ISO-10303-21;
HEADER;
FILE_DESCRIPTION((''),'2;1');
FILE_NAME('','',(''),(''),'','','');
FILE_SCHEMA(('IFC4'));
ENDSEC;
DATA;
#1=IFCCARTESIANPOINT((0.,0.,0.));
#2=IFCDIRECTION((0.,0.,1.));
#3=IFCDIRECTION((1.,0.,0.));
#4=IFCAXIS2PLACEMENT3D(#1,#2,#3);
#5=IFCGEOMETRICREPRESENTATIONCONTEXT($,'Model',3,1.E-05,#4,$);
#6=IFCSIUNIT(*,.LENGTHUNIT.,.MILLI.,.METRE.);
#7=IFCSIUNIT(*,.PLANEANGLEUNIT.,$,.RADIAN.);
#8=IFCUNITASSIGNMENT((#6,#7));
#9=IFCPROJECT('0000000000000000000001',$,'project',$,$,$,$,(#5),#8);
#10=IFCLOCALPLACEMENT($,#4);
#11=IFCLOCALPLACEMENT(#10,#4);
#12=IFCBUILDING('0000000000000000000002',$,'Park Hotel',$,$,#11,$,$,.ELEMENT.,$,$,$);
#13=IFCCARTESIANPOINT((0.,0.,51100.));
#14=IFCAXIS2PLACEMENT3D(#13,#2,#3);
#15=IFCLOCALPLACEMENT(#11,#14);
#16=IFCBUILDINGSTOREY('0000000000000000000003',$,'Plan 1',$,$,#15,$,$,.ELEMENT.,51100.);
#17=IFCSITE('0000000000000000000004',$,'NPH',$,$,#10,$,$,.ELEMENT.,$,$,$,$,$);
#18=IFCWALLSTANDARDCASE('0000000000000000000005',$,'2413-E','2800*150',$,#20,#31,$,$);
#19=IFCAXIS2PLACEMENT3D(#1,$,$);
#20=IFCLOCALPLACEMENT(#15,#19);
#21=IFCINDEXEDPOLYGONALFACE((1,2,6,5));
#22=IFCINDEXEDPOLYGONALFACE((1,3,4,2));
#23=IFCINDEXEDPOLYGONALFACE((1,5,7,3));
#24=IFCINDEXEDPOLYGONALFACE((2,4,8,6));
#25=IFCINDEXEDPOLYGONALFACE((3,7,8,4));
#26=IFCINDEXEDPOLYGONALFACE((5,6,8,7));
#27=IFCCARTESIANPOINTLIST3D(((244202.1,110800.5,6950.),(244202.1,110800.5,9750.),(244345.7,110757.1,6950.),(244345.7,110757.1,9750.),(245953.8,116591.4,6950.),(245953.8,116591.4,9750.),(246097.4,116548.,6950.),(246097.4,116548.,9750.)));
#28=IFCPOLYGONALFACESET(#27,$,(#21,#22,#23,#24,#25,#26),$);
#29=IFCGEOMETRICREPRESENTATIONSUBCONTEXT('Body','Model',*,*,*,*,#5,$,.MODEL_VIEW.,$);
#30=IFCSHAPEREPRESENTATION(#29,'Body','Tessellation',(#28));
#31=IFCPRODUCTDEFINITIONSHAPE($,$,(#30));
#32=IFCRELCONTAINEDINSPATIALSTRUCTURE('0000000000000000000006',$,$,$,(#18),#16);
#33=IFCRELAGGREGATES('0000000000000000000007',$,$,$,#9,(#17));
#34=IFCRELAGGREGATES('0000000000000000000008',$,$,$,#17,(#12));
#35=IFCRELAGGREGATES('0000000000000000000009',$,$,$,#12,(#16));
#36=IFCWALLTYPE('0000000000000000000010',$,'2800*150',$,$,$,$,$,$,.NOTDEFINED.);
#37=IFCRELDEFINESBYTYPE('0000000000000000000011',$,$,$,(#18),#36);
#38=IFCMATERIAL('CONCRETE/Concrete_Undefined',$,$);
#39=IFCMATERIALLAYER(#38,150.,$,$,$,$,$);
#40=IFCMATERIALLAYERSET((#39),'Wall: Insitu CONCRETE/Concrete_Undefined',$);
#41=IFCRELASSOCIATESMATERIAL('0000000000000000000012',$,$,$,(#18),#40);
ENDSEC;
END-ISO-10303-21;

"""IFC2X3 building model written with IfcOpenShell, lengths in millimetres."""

from ifc_helpers import new_model, si_unit, frame, frame_2d, origin_with_axes, place, context, subcontext, project, spatial, rectangle, extrude, material, layer, layer_set, layer_usage, type_object, element, save


model = new_model("IFC2X3")

# Units and contexts
model_context = context("Model", 3, precision=1e-05, world=origin_with_axes())
body_context = subcontext(model_context, "Body", "Model", "MODEL_VIEW")
ifc_project = project(units=[si_unit("LENGTHUNIT", "METRE", prefix="MILLI"), si_unit("PLANEANGLEUNIT", "RADIAN")], contexts=[model_context])

# Site, building, storey
site_placement = place(None, origin_with_axes())
site = spatial("IfcSite", under=ifc_project, at=site_placement, Name="NPH", CompositionType="ELEMENT")
building_placement = place(site_placement, origin_with_axes())
building = spatial("IfcBuilding", under=site, at=building_placement, Name="Park Hotel", CompositionType="ELEMENT")
storey_placement = place(building_placement, frame((0.0, 0.0, 51100.0), z_axis=(0.0, 0.0, 1.0), x_axis=(1.0, 0.0, 0.0)))
storey = spatial("IfcBuildingStorey", under=building, at=storey_placement, Name="Plan 1", CompositionType="ELEMENT", Elevation=51100.0)

# Shared definitions
ifc_material_1 = material(Name="CONCRETE/Concrete_Undefined")

# Wall
ifc_layer_1 = layer(ifc_material_1, 150.0)
ifc_layer_set_1 = layer_set([ifc_layer_1], Name="Wall: Insitu CONCRETE/Concrete_Undefined")
ifc_layer_usage_1 = layer_usage(ifc_layer_set_1, "AXIS2", "POSITIVE", -75.0)
wall_type_1 = type_object("IfcWallType", Name="2800*150", PredefinedType="NOTDEFINED")
wall_1_placement = place(storey_placement, frame((244273.9, 110778.8, 6950.0), z_axis=(0.0, 0.0, 1.0), x_axis=(0.289537, 0.957167, 0.0)))
element("IfcWallStandardCase", 1, at=wall_1_placement, inside=storey, type_object=wall_type_1, material=ifc_layer_usage_1, Name="2413-E", Description="2800*150", context=body_context, shape_type="SweptSolid", body=[
    extrude(rectangle(XDim=6050.0, YDim=150.0, at=frame_2d((0.0, 3025.0), x_axis=(0.0, -1.0))), frame((0.0, 0.0, 0.0), z_axis=(0.0, 0.0, 1.0), x_axis=(0.0, -1.0, 0.0)), (0.0, 0.0, 1.0), 2800.0),
])

save(model, "model.ifc")
